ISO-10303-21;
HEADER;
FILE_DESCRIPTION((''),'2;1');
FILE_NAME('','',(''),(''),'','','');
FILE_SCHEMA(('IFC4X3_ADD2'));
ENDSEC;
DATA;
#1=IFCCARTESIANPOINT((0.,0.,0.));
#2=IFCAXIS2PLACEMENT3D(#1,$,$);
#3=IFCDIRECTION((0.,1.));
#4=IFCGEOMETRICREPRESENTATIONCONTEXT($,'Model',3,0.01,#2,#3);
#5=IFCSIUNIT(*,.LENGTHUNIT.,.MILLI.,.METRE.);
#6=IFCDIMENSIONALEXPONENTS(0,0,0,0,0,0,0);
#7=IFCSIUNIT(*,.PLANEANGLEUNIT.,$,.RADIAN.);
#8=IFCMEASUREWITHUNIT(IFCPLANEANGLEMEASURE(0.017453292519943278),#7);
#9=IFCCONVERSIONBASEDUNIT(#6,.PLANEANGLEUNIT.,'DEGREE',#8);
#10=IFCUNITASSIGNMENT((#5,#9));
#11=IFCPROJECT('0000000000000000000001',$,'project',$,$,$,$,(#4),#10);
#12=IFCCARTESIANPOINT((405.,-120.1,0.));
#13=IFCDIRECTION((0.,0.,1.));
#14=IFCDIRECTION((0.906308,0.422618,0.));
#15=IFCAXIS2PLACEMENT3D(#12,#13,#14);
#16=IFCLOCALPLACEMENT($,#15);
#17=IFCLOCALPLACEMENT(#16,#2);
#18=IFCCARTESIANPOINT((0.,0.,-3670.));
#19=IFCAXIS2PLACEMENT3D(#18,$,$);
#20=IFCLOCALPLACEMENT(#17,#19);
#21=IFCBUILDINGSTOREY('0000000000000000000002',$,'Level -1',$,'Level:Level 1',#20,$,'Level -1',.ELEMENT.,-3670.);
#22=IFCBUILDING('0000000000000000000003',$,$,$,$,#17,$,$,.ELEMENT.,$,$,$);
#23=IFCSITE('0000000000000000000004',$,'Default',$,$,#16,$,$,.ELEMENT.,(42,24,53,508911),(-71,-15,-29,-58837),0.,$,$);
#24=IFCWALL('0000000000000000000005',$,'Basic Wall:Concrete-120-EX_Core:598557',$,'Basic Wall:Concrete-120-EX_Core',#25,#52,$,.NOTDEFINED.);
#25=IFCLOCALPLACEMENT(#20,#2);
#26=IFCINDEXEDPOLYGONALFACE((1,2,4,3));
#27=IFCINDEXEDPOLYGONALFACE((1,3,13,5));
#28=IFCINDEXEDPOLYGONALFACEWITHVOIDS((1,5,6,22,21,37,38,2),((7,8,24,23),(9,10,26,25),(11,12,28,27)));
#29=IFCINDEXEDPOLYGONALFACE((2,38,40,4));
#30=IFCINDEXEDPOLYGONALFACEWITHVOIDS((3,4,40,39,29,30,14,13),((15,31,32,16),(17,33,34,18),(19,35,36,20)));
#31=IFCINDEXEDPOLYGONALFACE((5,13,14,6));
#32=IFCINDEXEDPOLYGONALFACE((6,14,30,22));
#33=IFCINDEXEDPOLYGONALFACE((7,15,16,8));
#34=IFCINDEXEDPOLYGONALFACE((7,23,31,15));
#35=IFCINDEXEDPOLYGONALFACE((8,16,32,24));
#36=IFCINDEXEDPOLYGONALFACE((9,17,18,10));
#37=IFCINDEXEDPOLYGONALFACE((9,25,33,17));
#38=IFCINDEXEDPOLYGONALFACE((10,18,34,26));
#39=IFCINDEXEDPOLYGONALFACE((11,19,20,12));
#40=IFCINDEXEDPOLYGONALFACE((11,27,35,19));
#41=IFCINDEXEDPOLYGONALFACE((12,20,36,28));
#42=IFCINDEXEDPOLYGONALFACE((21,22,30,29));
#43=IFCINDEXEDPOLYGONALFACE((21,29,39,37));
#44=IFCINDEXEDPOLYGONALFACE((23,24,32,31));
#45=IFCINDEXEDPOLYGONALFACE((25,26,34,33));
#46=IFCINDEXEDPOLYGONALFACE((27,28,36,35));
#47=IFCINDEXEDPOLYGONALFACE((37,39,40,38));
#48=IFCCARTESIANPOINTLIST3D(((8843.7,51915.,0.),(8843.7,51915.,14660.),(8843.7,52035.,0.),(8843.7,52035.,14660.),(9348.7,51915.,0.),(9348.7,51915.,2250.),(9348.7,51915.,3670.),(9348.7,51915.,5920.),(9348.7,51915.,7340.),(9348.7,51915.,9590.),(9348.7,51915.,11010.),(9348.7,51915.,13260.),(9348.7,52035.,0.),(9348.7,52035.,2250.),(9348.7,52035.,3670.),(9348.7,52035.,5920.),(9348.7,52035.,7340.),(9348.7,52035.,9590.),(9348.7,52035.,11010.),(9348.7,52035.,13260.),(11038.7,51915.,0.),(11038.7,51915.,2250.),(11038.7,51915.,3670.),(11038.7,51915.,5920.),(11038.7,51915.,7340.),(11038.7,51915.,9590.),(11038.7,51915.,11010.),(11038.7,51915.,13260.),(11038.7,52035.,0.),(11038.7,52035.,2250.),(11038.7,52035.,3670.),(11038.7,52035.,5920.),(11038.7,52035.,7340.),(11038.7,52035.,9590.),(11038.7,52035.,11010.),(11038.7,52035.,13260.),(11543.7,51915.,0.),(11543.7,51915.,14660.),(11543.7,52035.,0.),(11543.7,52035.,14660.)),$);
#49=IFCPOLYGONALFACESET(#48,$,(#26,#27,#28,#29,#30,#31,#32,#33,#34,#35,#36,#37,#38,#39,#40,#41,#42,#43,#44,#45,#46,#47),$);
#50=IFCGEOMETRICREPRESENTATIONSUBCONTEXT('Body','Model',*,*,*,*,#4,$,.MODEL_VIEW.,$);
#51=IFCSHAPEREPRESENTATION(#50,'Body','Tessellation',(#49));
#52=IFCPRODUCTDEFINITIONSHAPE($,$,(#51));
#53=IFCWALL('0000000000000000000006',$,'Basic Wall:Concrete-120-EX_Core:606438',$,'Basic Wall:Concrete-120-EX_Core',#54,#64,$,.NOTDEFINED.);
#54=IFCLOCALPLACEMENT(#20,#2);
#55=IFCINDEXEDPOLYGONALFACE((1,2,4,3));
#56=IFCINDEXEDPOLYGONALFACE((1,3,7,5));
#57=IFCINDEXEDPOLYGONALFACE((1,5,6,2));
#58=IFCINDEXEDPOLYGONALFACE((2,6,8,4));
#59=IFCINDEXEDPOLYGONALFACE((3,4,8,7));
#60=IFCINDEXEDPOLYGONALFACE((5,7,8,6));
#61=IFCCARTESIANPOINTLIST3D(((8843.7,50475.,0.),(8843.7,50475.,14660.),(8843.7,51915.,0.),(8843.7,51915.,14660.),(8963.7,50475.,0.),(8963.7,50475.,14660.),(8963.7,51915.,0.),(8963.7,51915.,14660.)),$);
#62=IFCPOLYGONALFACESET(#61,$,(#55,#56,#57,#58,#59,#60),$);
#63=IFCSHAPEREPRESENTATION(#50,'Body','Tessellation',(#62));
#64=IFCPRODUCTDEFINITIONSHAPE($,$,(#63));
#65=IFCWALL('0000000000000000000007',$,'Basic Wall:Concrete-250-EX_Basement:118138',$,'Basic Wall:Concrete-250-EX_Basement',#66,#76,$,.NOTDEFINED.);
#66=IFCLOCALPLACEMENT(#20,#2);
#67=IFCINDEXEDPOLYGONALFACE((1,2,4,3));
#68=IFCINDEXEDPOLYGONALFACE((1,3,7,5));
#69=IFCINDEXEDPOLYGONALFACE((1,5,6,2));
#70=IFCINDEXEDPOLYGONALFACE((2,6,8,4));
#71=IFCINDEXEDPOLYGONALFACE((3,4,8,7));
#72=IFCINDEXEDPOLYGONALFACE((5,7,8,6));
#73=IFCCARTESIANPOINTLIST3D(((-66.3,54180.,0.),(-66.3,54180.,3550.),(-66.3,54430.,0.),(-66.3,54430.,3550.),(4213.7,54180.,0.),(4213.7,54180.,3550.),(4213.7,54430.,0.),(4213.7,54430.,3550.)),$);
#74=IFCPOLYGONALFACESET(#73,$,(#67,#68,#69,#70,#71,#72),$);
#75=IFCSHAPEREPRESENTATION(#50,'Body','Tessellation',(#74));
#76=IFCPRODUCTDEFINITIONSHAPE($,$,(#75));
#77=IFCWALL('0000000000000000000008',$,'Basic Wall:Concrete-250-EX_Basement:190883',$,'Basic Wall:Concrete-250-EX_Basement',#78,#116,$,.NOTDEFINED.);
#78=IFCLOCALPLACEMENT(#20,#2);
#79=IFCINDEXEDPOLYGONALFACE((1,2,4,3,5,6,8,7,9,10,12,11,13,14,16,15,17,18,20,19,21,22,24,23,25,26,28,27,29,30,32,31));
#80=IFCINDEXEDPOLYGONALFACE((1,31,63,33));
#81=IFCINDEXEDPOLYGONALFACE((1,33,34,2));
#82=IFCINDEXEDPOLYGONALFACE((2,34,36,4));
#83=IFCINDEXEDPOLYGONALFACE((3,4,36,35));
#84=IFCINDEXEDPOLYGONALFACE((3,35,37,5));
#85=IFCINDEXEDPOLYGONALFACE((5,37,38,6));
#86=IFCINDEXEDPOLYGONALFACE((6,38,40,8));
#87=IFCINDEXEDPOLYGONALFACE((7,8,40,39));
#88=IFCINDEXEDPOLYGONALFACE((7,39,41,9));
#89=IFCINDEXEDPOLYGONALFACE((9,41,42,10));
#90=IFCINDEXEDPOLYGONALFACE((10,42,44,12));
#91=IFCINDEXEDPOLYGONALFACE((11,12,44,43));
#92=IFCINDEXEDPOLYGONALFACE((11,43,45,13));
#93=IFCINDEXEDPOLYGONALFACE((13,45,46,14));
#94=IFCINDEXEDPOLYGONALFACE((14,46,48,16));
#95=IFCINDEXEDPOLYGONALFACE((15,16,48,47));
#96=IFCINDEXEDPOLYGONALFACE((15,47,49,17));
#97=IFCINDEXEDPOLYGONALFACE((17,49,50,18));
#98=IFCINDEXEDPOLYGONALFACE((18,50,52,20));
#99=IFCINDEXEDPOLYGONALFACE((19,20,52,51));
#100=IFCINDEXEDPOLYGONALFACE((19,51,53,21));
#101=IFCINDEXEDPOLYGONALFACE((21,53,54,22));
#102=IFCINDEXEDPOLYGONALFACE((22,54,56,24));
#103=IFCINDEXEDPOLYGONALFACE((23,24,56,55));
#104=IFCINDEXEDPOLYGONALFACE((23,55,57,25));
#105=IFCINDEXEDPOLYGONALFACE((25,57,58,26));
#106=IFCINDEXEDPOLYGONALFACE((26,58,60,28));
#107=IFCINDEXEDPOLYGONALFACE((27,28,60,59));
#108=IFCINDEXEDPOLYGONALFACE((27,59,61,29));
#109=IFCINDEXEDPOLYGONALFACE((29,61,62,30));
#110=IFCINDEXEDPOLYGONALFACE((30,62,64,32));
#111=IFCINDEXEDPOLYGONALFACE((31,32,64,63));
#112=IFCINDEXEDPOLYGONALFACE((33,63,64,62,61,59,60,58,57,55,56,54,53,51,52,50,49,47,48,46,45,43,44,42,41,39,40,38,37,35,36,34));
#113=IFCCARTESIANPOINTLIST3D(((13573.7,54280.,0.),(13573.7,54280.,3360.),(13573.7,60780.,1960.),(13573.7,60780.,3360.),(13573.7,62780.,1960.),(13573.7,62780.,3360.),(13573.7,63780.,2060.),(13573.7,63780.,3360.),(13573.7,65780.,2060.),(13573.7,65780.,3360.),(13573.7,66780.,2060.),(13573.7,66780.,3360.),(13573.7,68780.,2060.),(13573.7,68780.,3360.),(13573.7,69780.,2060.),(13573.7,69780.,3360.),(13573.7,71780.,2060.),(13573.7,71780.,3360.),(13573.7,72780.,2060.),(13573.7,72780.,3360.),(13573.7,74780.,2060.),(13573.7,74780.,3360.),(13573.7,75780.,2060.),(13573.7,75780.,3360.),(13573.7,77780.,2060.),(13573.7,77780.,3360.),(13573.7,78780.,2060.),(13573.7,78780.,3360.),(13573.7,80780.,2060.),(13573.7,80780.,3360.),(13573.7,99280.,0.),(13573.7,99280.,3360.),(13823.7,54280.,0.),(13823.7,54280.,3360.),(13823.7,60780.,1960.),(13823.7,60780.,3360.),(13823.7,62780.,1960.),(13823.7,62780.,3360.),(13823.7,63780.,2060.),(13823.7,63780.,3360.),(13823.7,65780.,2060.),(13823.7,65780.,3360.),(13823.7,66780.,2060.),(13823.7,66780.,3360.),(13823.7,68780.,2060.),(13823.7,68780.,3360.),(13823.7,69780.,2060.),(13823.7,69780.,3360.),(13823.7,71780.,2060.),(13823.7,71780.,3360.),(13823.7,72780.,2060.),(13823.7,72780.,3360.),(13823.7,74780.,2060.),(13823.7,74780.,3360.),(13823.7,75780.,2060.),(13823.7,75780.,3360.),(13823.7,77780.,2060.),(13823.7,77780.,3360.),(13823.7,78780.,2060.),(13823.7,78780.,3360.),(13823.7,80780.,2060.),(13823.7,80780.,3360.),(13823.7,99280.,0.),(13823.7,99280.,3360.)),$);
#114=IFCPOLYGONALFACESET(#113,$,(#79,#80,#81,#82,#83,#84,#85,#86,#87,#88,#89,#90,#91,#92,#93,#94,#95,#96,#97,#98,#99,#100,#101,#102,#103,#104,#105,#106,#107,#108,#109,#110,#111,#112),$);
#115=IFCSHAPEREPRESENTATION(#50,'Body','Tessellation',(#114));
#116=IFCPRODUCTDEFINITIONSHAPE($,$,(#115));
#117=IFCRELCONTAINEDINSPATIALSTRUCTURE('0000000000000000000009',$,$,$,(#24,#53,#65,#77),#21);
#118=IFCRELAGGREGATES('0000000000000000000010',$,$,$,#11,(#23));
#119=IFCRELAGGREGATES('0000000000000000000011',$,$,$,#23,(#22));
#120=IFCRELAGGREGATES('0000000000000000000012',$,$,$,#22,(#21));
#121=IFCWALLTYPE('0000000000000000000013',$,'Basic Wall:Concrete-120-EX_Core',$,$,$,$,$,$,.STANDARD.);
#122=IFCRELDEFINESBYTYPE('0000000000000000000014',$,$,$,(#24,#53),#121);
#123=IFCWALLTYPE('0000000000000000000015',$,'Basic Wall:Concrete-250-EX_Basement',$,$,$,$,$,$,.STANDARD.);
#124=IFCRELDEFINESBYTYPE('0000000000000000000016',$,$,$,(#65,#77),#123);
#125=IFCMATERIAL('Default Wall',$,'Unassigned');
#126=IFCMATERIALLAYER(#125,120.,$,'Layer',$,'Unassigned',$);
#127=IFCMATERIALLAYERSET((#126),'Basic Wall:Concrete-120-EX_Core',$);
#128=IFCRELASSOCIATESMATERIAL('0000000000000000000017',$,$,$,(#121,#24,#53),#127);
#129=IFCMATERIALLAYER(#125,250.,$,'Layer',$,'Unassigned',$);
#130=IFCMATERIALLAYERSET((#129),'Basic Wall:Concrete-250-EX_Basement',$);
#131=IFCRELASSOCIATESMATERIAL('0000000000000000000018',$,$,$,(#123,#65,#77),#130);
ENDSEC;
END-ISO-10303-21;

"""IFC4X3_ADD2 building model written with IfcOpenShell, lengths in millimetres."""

from ifc_helpers import new_model, entity, si_unit, converted_unit, direction, frame, frame_2d, origin, place, context, subcontext, project, spatial, rectangle, extrude, material, layer, layer_set, type_object, element, save


model = new_model("IFC4X3_ADD2")

# Units and contexts
model_context = context("Model", 3, precision=0.01, world=origin(), true_north=direction((0.0, 1.0)))
body_context = subcontext(model_context, "Body", "Model", "MODEL_VIEW")
ifc_project = project(units=[si_unit("LENGTHUNIT", "METRE", prefix="MILLI"), converted_unit("PLANEANGLEUNIT", "DEGREE", entity("IfcPlaneAngleMeasure", 0.017453292519943278), si_unit("PLANEANGLEUNIT", "RADIAN"), dimensions=[0, 0, 0, 0, 0, 0, 0])], contexts=[model_context])

# Site, building, storey
site_placement = place(None, frame((405.0, -120.1, 0.0), z_axis=(0.0, 0.0, 1.0), x_axis=(0.906308, 0.422618, 0.0)))
site = spatial("IfcSite", under=ifc_project, at=site_placement, Name="Default", CompositionType="ELEMENT", RefLatitude=(42, 24, 53, 508911), RefLongitude=(-71, -15, -29, -58837), RefElevation=0.0)
building_placement = place(site_placement, origin())
building = spatial("IfcBuilding", under=site, at=building_placement, CompositionType="ELEMENT")
storey_placement = place(building_placement, frame((0.0, 0.0, -3670.0)))
storey = spatial("IfcBuildingStorey", under=building, at=storey_placement, Name="Level -1", ObjectType="Level:Level 1", LongName="Level -1", CompositionType="ELEMENT", Elevation=-3670.0)

# Wall, openings
ifc_material = material(Name="Default Wall", Category="Unassigned")
ifc_layer_1 = layer(ifc_material, 120.0, Name="Layer", Category="Unassigned")
ifc_layer_set_1 = layer_set([ifc_layer_1], Name="Basic Wall:Concrete-120-EX_Core")
wall_type_1 = type_object("IfcWallType", Name="Basic Wall:Concrete-120-EX_Core", PredefinedType="STANDARD", material=ifc_layer_set_1)
wall_1_placement = place(storey_placement, frame((11543.7, 51975.0, 0.0), z_axis=(0.0, 0.0, 1.0), x_axis=(-1.0, 0.0, 0.0)))
wall_1 = element("IfcWall", 1, at=wall_1_placement, inside=storey, type_object=wall_type_1, material=ifc_layer_set_1, Name="Basic Wall:Concrete-120-EX_Core:598557", ObjectType="Basic Wall:Concrete-120-EX_Core", PredefinedType="NOTDEFINED", context=body_context, shape_type="SweptSolid", body=[
    extrude(rectangle(XDim=2700.0, YDim=120.0, at=frame_2d((1350.0, 0.0), x_axis=(-1.0, 0.0))), origin(), (0.0, 0.0, 1.0), 14660.0),
])
opening_1_placement = place(wall_1_placement, origin())
element("IfcOpeningElement", 2, at=opening_1_placement, cuts=wall_1, PredefinedType="OPENING", context=body_context, shape_type="SweptSolid", body=[
    extrude(rectangle(XDim=2250.0, YDim=1690.0, at=frame_2d((0.0, 0.0), x_axis=(1.0, 0.0))), frame((1350.0, 60.0, 12135.0), z_axis=(0.0, 1.0, 0.0), x_axis=(0.0, 0.0, 1.0)), (0.0, 0.0, -1.0), 120.0),
])
opening_2_placement = place(wall_1_placement, origin())
element("IfcOpeningElement", 3, at=opening_2_placement, cuts=wall_1, PredefinedType="OPENING", context=body_context, shape_type="SweptSolid", body=[
    extrude(rectangle(XDim=2250.0, YDim=1690.0, at=frame_2d((0.0, 0.0), x_axis=(1.0, 0.0))), frame((1350.0, 60.0, 8465.0), z_axis=(0.0, 1.0, 0.0), x_axis=(0.0, 0.0, 1.0)), (0.0, 0.0, -1.0), 120.0),
])
opening_3_placement = place(wall_1_placement, origin())
element("IfcOpeningElement", 4, at=opening_3_placement, cuts=wall_1, PredefinedType="OPENING", context=body_context, shape_type="SweptSolid", body=[
    extrude(rectangle(XDim=2250.0, YDim=1690.0, at=frame_2d((0.0, 0.0), x_axis=(1.0, 0.0))), frame((1350.0, 60.0, 4795.0), z_axis=(0.0, 1.0, 0.0), x_axis=(0.0, 0.0, 1.0)), (0.0, 0.0, -1.0), 120.0),
])
opening_4_placement = place(wall_1_placement, origin())
element("IfcOpeningElement", 5, at=opening_4_placement, cuts=wall_1, PredefinedType="OPENING", context=body_context, shape_type="SweptSolid", body=[
    extrude(rectangle(XDim=2250.0, YDim=1690.0, at=frame_2d((0.0, 0.0), x_axis=(0.0, 1.0))), frame((1350.0, 60.0, 1125.0), z_axis=(0.0, -1.0, 0.0), x_axis=(1.0, 0.0, 0.0)), (0.0, 0.0, 1.0), 120.0),
])

# Walls
wall_2_placement = place(storey_placement, frame((8903.7, 50475.0, 0.0), z_axis=(0.0, 0.0, 1.0), x_axis=(0.0, 1.0, 0.0)))
element("IfcWall", 6, at=wall_2_placement, inside=storey, type_object=wall_type_1, material=ifc_layer_set_1, Name="Basic Wall:Concrete-120-EX_Core:606438", ObjectType="Basic Wall:Concrete-120-EX_Core", PredefinedType="NOTDEFINED", context=body_context, shape_type="SweptSolid", body=[
    extrude(rectangle(XDim=1440.0, YDim=120.0, at=frame_2d((720.0, 0.0), x_axis=(-1.0, 0.0))), origin(), (0.0, 0.0, 1.0), 14660.0),
])
ifc_layer_2 = layer(ifc_material, 250.0, Name="Layer", Category="Unassigned")
ifc_layer_set_2 = layer_set([ifc_layer_2], Name="Basic Wall:Concrete-250-EX_Basement")
wall_type_2 = type_object("IfcWallType", Name="Basic Wall:Concrete-250-EX_Basement", PredefinedType="STANDARD", material=ifc_layer_set_2)
wall_3_placement = place(storey_placement, frame((-66.3, 54305.0, 0.0)))
element("IfcWall", 7, at=wall_3_placement, inside=storey, type_object=wall_type_2, material=ifc_layer_set_2, Name="Basic Wall:Concrete-250-EX_Basement:118138", ObjectType="Basic Wall:Concrete-250-EX_Basement", PredefinedType="NOTDEFINED", context=body_context, shape_type="SweptSolid", body=[
    extrude(rectangle(XDim=4280.0, YDim=250.0, at=frame_2d((2140.0, 0.0), x_axis=(-1.0, 0.0))), origin(), (0.0, 0.0, 1.0), 3550.0),
])

# Wall, openings
wall_4_placement = place(storey_placement, frame((13698.7, 99280.0, 0.0), z_axis=(0.0, 0.0, 1.0), x_axis=(0.0, -1.0, 0.0)))
wall_4 = element("IfcWall", 8, at=wall_4_placement, inside=storey, type_object=wall_type_2, material=ifc_layer_set_2, Name="Basic Wall:Concrete-250-EX_Basement:190883", ObjectType="Basic Wall:Concrete-250-EX_Basement", PredefinedType="NOTDEFINED", context=body_context, shape_type="SweptSolid", body=[
    extrude(rectangle(XDim=45000.0, YDim=250.0, at=frame_2d((22500.0, 0.0), x_axis=(-1.0, 0.0))), origin(), (0.0, 0.0, 1.0), 3360.0),
])
opening_5_placement = place(wall_4_placement, origin())
element("IfcOpeningElement", 9, at=opening_5_placement, cuts=wall_4, PredefinedType="OPENING", context=body_context, shape_type="SweptSolid", body=[
    extrude(rectangle(XDim=1400.0, YDim=2000.0, at=frame_2d((0.0, 0.0), x_axis=(0.0, 1.0))), frame((37500.0, 125.0, 2660.0), z_axis=(0.0, -1.0, 0.0), x_axis=(-1.0, 0.0, 0.0)), (0.0, 0.0, 1.0), 250.0),
])
opening_6_placement = place(wall_4_placement, origin())
element("IfcOpeningElement", 10, at=opening_6_placement, cuts=wall_4, PredefinedType="OPENING", context=body_context, shape_type="SweptSolid", body=[
    extrude(rectangle(XDim=1300.0, YDim=2000.0, at=frame_2d((0.0, 0.0), x_axis=(0.0, 1.0))), frame((34500.0, 125.0, 2710.0), z_axis=(0.0, -1.0, 0.0), x_axis=(-1.0, 0.0, 0.0)), (0.0, 0.0, 1.0), 250.0),
])
opening_7_placement = place(wall_4_placement, origin())
element("IfcOpeningElement", 11, at=opening_7_placement, cuts=wall_4, PredefinedType="OPENING", context=body_context, shape_type="SweptSolid", body=[
    extrude(rectangle(XDim=1300.0, YDim=2000.0, at=frame_2d((0.0, 0.0), x_axis=(0.0, 1.0))), frame((31500.0, 125.0, 2710.0), z_axis=(0.0, -1.0, 0.0), x_axis=(-1.0, 0.0, 0.0)), (0.0, 0.0, 1.0), 250.0),
])
opening_8_placement = place(wall_4_placement, origin())
element("IfcOpeningElement", 12, at=opening_8_placement, cuts=wall_4, PredefinedType="OPENING", context=body_context, shape_type="SweptSolid", body=[
    extrude(rectangle(XDim=1300.0, YDim=2000.0, at=frame_2d((0.0, 0.0), x_axis=(0.0, 1.0))), frame((28500.0, 125.0, 2710.0), z_axis=(0.0, -1.0, 0.0), x_axis=(-1.0, 0.0, 0.0)), (0.0, 0.0, 1.0), 250.0),
])
opening_9_placement = place(wall_4_placement, origin())
element("IfcOpeningElement", 13, at=opening_9_placement, cuts=wall_4, PredefinedType="OPENING", context=body_context, shape_type="SweptSolid", body=[
    extrude(rectangle(XDim=1300.0, YDim=2000.0, at=frame_2d((0.0, 0.0), x_axis=(0.0, 1.0))), frame((25500.0, 125.0, 2710.0), z_axis=(0.0, -1.0, 0.0), x_axis=(-1.0, 0.0, 0.0)), (0.0, 0.0, 1.0), 250.0),
])
opening_10_placement = place(wall_4_placement, origin())
element("IfcOpeningElement", 14, at=opening_10_placement, cuts=wall_4, PredefinedType="OPENING", context=body_context, shape_type="SweptSolid", body=[
    extrude(rectangle(XDim=1300.0, YDim=2000.0, at=frame_2d((0.0, 0.0), x_axis=(0.0, 1.0))), frame((22500.0, 125.0, 2710.0), z_axis=(0.0, -1.0, 0.0), x_axis=(-1.0, 0.0, 0.0)), (0.0, 0.0, 1.0), 250.0),
])
opening_11_placement = place(wall_4_placement, origin())
element("IfcOpeningElement", 15, at=opening_11_placement, cuts=wall_4, PredefinedType="OPENING", context=body_context, shape_type="SweptSolid", body=[
    extrude(rectangle(XDim=1300.0, YDim=2000.0, at=frame_2d((0.0, 0.0), x_axis=(0.0, 1.0))), frame((19500.0, 125.0, 2710.0), z_axis=(0.0, -1.0, 0.0), x_axis=(-1.0, 0.0, 0.0)), (0.0, 0.0, 1.0), 250.0),
])

save(model, "model.ifc")
